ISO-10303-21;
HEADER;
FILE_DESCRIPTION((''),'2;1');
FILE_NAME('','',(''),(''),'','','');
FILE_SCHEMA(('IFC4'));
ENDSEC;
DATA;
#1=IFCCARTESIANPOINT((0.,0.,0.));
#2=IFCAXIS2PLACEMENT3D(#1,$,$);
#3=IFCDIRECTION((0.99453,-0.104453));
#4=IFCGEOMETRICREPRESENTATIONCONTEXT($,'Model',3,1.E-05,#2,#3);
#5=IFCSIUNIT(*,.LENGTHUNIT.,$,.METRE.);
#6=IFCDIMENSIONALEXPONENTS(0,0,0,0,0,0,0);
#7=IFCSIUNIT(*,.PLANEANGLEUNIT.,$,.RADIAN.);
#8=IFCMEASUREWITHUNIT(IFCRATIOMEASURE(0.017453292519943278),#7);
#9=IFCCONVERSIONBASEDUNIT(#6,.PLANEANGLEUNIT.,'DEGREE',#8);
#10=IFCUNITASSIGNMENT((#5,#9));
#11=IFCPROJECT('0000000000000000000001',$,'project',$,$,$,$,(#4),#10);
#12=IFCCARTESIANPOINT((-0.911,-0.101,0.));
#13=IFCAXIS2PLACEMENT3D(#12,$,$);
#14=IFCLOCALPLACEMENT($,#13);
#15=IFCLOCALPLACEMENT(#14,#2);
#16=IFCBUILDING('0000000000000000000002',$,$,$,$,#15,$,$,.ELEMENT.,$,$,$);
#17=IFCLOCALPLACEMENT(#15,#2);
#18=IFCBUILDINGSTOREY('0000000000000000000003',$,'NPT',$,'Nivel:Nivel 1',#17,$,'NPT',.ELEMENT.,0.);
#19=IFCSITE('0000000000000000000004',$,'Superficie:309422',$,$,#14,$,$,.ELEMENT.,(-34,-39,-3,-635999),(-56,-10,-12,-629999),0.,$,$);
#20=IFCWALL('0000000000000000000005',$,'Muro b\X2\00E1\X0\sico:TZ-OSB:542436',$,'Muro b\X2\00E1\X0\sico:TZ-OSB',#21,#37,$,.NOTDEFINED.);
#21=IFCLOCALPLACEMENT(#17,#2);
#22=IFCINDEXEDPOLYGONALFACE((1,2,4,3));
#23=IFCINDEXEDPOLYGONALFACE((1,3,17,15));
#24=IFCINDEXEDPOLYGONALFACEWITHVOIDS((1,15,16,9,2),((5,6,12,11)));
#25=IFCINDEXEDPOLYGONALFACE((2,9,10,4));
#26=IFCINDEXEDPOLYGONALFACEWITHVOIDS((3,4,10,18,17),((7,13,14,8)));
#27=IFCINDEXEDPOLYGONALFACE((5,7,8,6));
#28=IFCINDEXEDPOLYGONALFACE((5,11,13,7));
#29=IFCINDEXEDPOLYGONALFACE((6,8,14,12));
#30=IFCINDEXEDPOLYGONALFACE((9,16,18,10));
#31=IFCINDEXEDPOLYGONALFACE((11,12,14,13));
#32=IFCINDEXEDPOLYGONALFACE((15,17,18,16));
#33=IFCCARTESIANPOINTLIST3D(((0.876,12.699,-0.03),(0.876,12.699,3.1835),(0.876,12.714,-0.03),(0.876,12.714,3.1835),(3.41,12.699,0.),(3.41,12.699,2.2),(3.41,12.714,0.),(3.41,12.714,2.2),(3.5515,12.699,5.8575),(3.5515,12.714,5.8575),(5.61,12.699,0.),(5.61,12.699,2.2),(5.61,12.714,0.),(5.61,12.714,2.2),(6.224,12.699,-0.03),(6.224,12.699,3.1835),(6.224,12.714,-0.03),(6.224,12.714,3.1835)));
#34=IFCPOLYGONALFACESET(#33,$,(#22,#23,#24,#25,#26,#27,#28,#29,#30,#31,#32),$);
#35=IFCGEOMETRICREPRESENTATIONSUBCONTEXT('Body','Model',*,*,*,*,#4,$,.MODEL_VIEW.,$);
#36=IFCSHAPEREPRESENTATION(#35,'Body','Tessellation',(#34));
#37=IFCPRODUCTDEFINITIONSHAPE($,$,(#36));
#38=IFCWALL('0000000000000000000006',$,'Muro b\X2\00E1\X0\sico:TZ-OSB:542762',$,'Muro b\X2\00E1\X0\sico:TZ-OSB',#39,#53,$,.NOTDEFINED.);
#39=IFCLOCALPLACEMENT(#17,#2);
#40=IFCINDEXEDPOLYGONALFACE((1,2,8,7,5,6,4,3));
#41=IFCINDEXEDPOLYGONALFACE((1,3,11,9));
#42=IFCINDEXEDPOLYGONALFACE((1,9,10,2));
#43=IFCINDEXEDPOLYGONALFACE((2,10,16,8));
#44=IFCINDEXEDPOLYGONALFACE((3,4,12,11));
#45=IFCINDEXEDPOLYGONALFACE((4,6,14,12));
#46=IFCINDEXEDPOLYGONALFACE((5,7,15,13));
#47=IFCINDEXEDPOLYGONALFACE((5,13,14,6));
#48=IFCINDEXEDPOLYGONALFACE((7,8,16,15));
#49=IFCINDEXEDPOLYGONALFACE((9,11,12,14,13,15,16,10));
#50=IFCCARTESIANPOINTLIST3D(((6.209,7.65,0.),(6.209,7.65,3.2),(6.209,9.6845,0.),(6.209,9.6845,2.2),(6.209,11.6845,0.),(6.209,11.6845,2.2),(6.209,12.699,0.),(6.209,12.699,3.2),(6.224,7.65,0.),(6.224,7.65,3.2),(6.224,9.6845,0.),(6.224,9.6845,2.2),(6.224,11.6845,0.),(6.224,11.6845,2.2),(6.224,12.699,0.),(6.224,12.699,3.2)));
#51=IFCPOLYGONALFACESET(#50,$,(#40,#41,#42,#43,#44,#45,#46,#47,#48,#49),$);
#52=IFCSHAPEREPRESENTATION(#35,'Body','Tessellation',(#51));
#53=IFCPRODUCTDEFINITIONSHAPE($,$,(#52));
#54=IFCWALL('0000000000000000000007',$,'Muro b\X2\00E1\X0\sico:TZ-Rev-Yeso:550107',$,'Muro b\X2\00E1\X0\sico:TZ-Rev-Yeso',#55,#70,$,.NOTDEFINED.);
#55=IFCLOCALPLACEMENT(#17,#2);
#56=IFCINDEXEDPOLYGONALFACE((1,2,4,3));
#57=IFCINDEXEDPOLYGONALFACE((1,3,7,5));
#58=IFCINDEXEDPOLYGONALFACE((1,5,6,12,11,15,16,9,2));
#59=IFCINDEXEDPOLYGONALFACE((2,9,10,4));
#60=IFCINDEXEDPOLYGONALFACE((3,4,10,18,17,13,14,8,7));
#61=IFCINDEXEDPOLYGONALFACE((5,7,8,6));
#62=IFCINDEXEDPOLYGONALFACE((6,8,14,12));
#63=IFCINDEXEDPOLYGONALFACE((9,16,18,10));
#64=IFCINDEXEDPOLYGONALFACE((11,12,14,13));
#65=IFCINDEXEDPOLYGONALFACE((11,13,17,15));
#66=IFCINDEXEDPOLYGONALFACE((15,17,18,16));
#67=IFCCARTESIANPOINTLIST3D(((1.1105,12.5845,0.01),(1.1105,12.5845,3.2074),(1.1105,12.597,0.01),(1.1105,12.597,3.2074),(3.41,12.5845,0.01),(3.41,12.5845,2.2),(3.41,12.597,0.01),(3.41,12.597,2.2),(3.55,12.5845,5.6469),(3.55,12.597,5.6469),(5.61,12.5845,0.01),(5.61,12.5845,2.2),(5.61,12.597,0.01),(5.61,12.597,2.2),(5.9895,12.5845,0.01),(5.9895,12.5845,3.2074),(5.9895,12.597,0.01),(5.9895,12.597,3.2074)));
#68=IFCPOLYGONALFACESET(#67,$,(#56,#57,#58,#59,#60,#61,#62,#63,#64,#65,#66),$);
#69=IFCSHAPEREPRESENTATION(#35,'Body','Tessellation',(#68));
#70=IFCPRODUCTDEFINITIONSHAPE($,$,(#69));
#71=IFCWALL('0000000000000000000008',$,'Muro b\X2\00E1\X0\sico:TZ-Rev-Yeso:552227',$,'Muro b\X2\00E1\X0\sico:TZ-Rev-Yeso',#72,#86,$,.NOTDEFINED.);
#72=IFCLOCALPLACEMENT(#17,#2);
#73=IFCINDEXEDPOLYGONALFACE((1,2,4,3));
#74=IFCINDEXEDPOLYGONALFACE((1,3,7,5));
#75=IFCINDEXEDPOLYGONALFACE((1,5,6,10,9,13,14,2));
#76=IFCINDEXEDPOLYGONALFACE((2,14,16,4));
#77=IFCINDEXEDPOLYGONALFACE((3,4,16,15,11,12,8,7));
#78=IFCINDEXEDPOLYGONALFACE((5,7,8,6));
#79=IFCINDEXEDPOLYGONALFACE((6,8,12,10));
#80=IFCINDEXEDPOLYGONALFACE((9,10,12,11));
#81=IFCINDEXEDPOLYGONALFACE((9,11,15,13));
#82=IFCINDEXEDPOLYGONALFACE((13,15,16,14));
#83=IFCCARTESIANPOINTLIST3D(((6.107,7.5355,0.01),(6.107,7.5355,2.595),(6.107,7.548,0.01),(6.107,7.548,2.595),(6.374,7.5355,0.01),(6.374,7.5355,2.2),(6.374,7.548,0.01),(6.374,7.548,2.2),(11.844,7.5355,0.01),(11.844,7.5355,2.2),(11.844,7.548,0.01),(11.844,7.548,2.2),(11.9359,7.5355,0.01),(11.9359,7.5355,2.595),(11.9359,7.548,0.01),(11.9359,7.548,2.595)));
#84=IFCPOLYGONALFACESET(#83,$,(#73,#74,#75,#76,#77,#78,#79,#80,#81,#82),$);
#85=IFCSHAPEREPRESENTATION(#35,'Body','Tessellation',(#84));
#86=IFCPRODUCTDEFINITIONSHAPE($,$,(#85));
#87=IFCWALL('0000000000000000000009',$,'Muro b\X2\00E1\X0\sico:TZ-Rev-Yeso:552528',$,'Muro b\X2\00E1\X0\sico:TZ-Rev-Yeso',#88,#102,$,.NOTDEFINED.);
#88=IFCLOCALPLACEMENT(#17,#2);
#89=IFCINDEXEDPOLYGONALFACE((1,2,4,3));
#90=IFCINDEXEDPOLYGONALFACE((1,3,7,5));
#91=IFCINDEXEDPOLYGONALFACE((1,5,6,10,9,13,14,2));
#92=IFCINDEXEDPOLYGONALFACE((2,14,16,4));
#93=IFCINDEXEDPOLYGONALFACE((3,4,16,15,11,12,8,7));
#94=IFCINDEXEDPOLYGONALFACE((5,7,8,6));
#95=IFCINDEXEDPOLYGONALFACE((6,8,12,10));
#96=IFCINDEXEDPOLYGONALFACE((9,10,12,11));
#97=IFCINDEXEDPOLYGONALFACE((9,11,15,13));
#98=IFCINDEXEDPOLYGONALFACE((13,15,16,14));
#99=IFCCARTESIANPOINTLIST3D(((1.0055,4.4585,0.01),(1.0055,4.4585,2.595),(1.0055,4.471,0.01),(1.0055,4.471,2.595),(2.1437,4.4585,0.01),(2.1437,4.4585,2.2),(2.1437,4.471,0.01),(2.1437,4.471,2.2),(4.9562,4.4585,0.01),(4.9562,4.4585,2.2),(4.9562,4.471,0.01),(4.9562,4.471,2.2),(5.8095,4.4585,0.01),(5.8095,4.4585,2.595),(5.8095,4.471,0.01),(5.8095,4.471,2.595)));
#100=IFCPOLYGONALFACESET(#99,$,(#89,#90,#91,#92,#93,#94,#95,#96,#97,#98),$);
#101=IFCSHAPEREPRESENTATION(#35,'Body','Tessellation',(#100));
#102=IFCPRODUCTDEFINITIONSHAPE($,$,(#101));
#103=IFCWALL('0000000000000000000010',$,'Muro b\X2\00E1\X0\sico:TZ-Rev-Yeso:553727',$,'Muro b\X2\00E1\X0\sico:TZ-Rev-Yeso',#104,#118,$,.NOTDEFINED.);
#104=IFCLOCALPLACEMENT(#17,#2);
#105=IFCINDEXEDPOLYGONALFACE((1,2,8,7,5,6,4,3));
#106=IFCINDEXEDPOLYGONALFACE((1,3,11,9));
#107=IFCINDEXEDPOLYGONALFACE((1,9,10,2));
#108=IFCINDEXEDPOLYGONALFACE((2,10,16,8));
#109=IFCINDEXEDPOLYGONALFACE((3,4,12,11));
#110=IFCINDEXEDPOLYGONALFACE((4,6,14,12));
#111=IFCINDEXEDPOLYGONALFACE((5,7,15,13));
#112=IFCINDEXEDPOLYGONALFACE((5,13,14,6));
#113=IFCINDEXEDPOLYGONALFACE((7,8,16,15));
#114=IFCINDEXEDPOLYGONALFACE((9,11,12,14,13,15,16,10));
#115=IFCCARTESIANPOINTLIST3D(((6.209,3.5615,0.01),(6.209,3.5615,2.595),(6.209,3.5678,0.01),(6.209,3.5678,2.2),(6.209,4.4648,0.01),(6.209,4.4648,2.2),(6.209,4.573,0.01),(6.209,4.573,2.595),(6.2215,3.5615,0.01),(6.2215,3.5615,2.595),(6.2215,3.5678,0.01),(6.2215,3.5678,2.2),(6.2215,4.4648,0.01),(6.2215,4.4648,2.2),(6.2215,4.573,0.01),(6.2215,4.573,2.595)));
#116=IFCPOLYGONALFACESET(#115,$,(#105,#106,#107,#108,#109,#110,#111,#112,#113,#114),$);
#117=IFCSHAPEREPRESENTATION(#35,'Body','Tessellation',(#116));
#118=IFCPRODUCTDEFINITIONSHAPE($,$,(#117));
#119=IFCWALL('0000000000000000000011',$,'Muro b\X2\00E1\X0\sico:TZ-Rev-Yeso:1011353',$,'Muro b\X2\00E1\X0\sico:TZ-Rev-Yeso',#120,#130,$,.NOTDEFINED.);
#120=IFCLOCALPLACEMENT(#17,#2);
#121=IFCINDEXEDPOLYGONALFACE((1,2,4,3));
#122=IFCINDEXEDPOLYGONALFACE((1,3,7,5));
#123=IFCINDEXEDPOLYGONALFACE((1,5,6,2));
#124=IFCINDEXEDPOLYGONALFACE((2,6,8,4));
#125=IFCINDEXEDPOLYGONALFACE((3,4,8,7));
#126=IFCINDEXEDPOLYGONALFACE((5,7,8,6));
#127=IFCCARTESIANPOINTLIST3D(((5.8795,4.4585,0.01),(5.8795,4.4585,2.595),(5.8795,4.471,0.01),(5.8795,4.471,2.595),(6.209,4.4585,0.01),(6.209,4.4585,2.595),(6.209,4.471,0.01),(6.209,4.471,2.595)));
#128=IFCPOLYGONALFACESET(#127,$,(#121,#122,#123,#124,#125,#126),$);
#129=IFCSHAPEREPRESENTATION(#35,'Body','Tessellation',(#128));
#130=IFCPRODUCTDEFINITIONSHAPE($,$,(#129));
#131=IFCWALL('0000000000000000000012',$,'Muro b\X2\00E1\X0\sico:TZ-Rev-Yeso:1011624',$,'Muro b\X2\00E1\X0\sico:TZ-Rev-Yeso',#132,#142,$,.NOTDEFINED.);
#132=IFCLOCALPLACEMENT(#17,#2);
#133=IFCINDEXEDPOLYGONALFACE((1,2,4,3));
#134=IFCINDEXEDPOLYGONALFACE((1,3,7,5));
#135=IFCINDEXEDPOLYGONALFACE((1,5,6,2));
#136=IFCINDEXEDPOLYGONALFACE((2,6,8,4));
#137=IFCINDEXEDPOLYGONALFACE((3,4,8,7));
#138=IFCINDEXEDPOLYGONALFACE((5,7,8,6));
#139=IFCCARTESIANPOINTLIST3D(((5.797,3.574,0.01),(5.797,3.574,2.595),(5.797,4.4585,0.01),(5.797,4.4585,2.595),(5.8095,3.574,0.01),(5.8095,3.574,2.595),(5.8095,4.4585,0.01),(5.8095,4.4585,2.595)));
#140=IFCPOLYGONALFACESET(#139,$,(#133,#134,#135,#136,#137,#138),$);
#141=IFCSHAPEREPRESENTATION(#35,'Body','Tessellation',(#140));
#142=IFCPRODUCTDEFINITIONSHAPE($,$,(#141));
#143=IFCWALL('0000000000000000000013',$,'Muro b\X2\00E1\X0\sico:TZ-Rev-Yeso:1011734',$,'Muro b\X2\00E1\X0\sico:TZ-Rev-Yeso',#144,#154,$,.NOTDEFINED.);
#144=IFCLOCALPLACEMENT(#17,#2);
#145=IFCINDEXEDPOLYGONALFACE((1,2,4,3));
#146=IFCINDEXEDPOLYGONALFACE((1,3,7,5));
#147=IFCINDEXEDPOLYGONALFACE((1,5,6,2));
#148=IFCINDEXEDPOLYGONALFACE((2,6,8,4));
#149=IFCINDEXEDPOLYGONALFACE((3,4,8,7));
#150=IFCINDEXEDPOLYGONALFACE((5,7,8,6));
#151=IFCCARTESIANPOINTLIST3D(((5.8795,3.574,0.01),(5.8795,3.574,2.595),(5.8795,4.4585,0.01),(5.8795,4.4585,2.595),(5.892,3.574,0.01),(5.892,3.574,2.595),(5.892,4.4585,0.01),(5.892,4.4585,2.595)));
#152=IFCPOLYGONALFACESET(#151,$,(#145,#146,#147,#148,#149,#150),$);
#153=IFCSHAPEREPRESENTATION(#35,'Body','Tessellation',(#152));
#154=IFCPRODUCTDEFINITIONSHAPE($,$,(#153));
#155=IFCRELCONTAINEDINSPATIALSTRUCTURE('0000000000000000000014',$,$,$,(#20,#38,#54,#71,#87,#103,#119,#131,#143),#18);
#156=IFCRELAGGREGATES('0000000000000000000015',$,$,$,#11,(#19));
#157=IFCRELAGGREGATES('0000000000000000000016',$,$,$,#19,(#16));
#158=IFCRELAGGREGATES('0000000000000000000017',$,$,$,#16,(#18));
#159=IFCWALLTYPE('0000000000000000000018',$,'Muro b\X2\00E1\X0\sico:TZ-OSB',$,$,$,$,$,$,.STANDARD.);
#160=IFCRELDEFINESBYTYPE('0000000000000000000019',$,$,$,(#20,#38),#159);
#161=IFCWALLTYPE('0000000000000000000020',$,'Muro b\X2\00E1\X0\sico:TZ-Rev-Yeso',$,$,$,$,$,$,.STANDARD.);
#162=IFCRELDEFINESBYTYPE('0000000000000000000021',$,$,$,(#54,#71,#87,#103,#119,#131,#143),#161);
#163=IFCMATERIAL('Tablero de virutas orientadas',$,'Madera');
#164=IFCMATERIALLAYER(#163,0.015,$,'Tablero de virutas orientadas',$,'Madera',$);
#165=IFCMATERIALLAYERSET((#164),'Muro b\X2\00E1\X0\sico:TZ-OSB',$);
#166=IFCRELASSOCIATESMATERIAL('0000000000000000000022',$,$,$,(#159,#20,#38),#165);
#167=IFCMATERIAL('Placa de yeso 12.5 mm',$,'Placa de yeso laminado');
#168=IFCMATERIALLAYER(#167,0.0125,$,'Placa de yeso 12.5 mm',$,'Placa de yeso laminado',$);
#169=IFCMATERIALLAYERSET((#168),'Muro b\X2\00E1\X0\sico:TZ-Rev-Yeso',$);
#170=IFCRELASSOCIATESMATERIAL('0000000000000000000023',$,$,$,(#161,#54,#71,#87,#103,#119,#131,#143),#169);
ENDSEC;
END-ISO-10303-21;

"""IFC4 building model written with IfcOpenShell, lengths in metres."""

from ifc_helpers import new_model, entity, si_unit, converted_unit, direction, frame, frame_2d, origin, origin_2d_with_axis, place, context, subcontext, project, spatial, rectangle, extrude, clip, halfspace, material, layer, layer_set, layer_usage, type_object, element, save


model = new_model("IFC4")

# Units and contexts
model_context = context("Model", 3, precision=1e-05, world=origin(), true_north=direction((0.99453, -0.104453)))
body_context = subcontext(model_context, "Body", "Model", "MODEL_VIEW")
ifc_project = project(units=[si_unit("LENGTHUNIT", "METRE"), converted_unit("PLANEANGLEUNIT", "DEGREE", entity("IfcRatioMeasure", 0.017453292519943278), si_unit("PLANEANGLEUNIT", "RADIAN"), dimensions=[0, 0, 0, 0, 0, 0, 0])], contexts=[model_context])

# Site, building, storey
site_placement = place(None, frame((-0.911, -0.101, 0.0)))
site = spatial("IfcSite", under=ifc_project, at=site_placement, Name="Superficie:309422", CompositionType="ELEMENT", RefLatitude=(-34, -39, -3, -635999), RefLongitude=(-56, -10, -12, -629999), RefElevation=0.0)
building_placement = place(site_placement, origin())
building = spatial("IfcBuilding", under=site, at=building_placement, CompositionType="ELEMENT")
storey_placement = place(building_placement, origin())
storey = spatial("IfcBuildingStorey", under=building, at=storey_placement, Name="NPT", ObjectType="Nivel:Nivel 1", LongName="NPT", CompositionType="ELEMENT", Elevation=0.0)

# Walls, openings
ifc_material_1 = material(Name="Tablero de virutas orientadas", Category="Madera")
ifc_layer_1 = layer(ifc_material_1, 0.015, Name="Tablero de virutas orientadas", Category="Madera")
ifc_layer_set_1 = layer_set([ifc_layer_1], Name="Muro básico:TZ-OSB")
ifc_layer_usage_1 = layer_usage(ifc_layer_set_1, "AXIS2", "NEGATIVE", 0.0075)
wall_type_1 = type_object("IfcWallType", Name="Muro básico:TZ-OSB", PredefinedType="STANDARD", material=ifc_layer_set_1)
wall_1_placement = place(storey_placement, frame((0.876, 12.7065, -0.03)))
wall_1 = element("IfcWall", 1, at=wall_1_placement, inside=storey, type_object=wall_type_1, material=ifc_layer_usage_1, Name="Muro básico:TZ-OSB:542436", ObjectType="Muro básico:TZ-OSB", PredefinedType="NOTDEFINED", context=body_context, shape_type="Clipping", body=[
    clip(clip(extrude(rectangle(XDim=5.348, YDim=0.015, at=frame_2d((2.674, 0.0), x_axis=(-1.0, 0.0))), origin(), (0.0, 0.0, 1.0), 5.8875), halfspace(frame((2.6755, -0.0075, 5.8875), z_axis=(0.707306, 0.0, 0.706908), x_axis=(0.0, 1.0, 0.0)), False)), halfspace(frame((0.0, -0.0075, 3.2135), z_axis=(-0.706908, 0.0, 0.707306), x_axis=(0.0, 1.0, 0.0)), False)),
])
opening_1_placement = place(wall_1_placement, frame((2.534, -1.6335, 0.03)))
element("IfcOpeningElement", 2, at=opening_1_placement, cuts=wall_1, PredefinedType="OPENING", context=body_context, shape_type="SweptSolid", body=[
    extrude(rectangle(XDim=2.2, YDim=2.2, at=origin_2d_with_axis()), frame((1.1, 0.0, 1.1), z_axis=(0.0, 1.0, 0.0), x_axis=(0.0, 0.0, 1.0)), (0.0, 0.0, 1.0), 3.048),
])
ifc_layer_usage_2 = layer_usage(ifc_layer_set_1, "AXIS2", "NEGATIVE", 0.0075)
wall_2_placement = place(storey_placement, frame((6.2165, 12.699, 0.0), z_axis=(0.0, 0.0, 1.0), x_axis=(0.0, -1.0, 0.0)))
wall_2 = element("IfcWall", 3, at=wall_2_placement, inside=storey, type_object=wall_type_1, material=ifc_layer_usage_2, Name="Muro básico:TZ-OSB:542762", ObjectType="Muro básico:TZ-OSB", PredefinedType="NOTDEFINED", context=body_context, shape_type="SweptSolid", body=[
    extrude(rectangle(XDim=5.049, YDim=0.015, at=frame_2d((2.5245, 0.0), x_axis=(1.0, 0.0))), origin(), (0.0, 0.0, 1.0), 3.2),
])
opening_2_placement = place(wall_2_placement, frame((3.0145, -1.6335, 0.0)))
element("IfcOpeningElement", 4, at=opening_2_placement, cuts=wall_2, PredefinedType="OPENING", context=body_context, shape_type="SweptSolid", body=[
    extrude(rectangle(XDim=2.2, YDim=2.0, at=frame_2d((0.0, 0.0), x_axis=(1.0, 0.0))), frame((-1.0, 0.0, 1.1), z_axis=(0.0, 1.0, 0.0), x_axis=(0.0, 0.0, 1.0)), (0.0, 0.0, 1.0), 3.048),
])
ifc_material_2 = material(Name="Placa de yeso 12.5 mm", Category="Placa de yeso laminado")
ifc_layer_2 = layer(ifc_material_2, 0.0125, Name="Placa de yeso 12.5 mm", Category="Placa de yeso laminado")
ifc_layer_set_2 = layer_set([ifc_layer_2], Name="Muro básico:TZ-Rev-Yeso")
ifc_layer_usage_3 = layer_usage(ifc_layer_set_2, "AXIS2", "NEGATIVE", 0.0063)
wall_type_2 = type_object("IfcWallType", Name="Muro básico:TZ-Rev-Yeso", PredefinedType="STANDARD", material=ifc_layer_set_2)
wall_3_placement = place(storey_placement, frame((1.1105, 12.5908, 0.01)))
wall_3 = element("IfcWall", 5, at=wall_3_placement, inside=storey, type_object=wall_type_2, material=ifc_layer_usage_3, Name="Muro básico:TZ-Rev-Yeso:550107", ObjectType="Muro básico:TZ-Rev-Yeso", PredefinedType="NOTDEFINED", context=body_context, shape_type="Clipping", body=[
    clip(clip(extrude(rectangle(XDim=4.879, YDim=0.0125, at=frame_2d((2.4395, 0.0), x_axis=(-1.0, 0.0))), origin(), (0.0, 0.0, 1.0), 5.6369), halfspace(frame((0.0, -0.0062, 3.1974), z_axis=(-0.707107, 0.0, 0.707107), x_axis=(0.0, 1.0, 0.0)), False)), halfspace(frame((2.4395, -0.0062, 5.6369), z_axis=(0.707107, 0.0, 0.707107), x_axis=(0.0, 1.0, 0.0)), False)),
])
opening_3_placement = place(wall_3_placement, frame((2.2995, -1.5177, -0.01)))
element("IfcOpeningElement", 6, at=opening_3_placement, cuts=wall_3, PredefinedType="OPENING", context=body_context, shape_type="SweptSolid", body=[
    extrude(rectangle(XDim=2.2, YDim=2.2, at=origin_2d_with_axis()), frame((1.1, 0.0, 1.1), z_axis=(0.0, 1.0, 0.0), x_axis=(0.0, 0.0, 1.0)), (0.0, 0.0, 1.0), 3.048),
])
ifc_layer_usage_4 = layer_usage(ifc_layer_set_2, "AXIS2", "NEGATIVE", 0.0063)
wall_4_placement = place(storey_placement, frame((6.107, 7.5417, 0.01)))
wall_4 = element("IfcWall", 7, at=wall_4_placement, inside=storey, type_object=wall_type_2, material=ifc_layer_usage_4, Name="Muro básico:TZ-Rev-Yeso:552227", ObjectType="Muro básico:TZ-Rev-Yeso", PredefinedType="NOTDEFINED", context=body_context, shape_type="SweptSolid", body=[
    extrude(rectangle(XDim=5.8289, YDim=0.0125, at=frame_2d((2.9145, 0.0), x_axis=(1.0, 0.0))), origin(), (0.0, 0.0, 1.0), 2.585),
])
opening_4_placement = place(wall_4_placement, frame((0.267, -1.5178, -0.01)))
element("IfcOpeningElement", 8, at=opening_4_placement, cuts=wall_4, PredefinedType="OPENING", context=body_context, shape_type="SweptSolid", body=[
    extrude(rectangle(XDim=2.2, YDim=5.47, at=frame_2d((0.0, 0.0), x_axis=(1.0, 0.0))), frame((2.735, 0.0, 1.1), z_axis=(0.0, 1.0, 0.0), x_axis=(0.0, 0.0, -1.0)), (0.0, 0.0, 1.0), 3.048),
])
ifc_layer_usage_5 = layer_usage(ifc_layer_set_2, "AXIS2", "NEGATIVE", 0.0063)
wall_5_placement = place(storey_placement, frame((1.0055, 4.4648, 0.01)))
wall_5 = element("IfcWall", 9, at=wall_5_placement, inside=storey, type_object=wall_type_2, material=ifc_layer_usage_5, Name="Muro básico:TZ-Rev-Yeso:552528", ObjectType="Muro básico:TZ-Rev-Yeso", PredefinedType="NOTDEFINED", context=body_context, shape_type="SweptSolid", body=[
    extrude(rectangle(XDim=4.804, YDim=0.0125, at=frame_2d((2.402, 0.0), x_axis=(-1.0, 0.0))), origin(), (0.0, 0.0, 1.0), 2.585),
])
opening_5_placement = place(wall_5_placement, origin())
element("IfcOpeningElement", 10, at=opening_5_placement, cuts=wall_5, PredefinedType="OPENING", context=body_context, shape_type="SweptSolid", body=[
    extrude(rectangle(XDim=2.19, YDim=2.8125, at=frame_2d((0.0, 0.0), x_axis=(0.0, 1.0))), frame((2.5445, 0.0063, 1.095), z_axis=(0.0, -1.0, 0.0), x_axis=(1.0, 0.0, 0.0)), (0.0, 0.0, 1.0), 0.0125),
])

# Wall, opening
ifc_layer_usage_6 = layer_usage(ifc_layer_set_2, "AXIS2", "POSITIVE", -0.0063)
wall_6_placement = place(storey_placement, frame((6.2153, 4.573, 0.01), z_axis=(0.0, 0.0, 1.0), x_axis=(0.0, -1.0, 0.0)))
wall_6 = element("IfcWall", 11, at=wall_6_placement, inside=storey, type_object=wall_type_2, material=ifc_layer_usage_6, Name="Muro básico:TZ-Rev-Yeso:553727", ObjectType="Muro básico:TZ-Rev-Yeso", PredefinedType="NOTDEFINED", context=body_context, shape_type="SweptSolid", body=[
    extrude(rectangle(XDim=1.0115, YDim=0.0125, at=frame_2d((0.5057, 0.0), x_axis=(-1.0, 0.0))), origin(), (0.0, 0.0, 1.0), 2.585),
])
opening_6_placement = place(wall_6_placement, origin())
element("IfcOpeningElement", 12, at=opening_6_placement, cuts=wall_6, PredefinedType="OPENING", context=body_context, shape_type="SweptSolid", body=[
    extrude(rectangle(XDim=2.19, YDim=0.897, at=frame_2d((0.0, 0.0), x_axis=(0.0, 1.0))), frame((0.5567, 0.0062, 1.095), z_axis=(0.0, -1.0, 0.0), x_axis=(-1.0, 0.0, 0.0)), (0.0, 0.0, 1.0), 0.0125),
])

# Walls
ifc_layer_usage_7 = layer_usage(ifc_layer_set_2, "AXIS2", "NEGATIVE", 0.0063)
wall_7_placement = place(storey_placement, frame((5.8795, 4.4648, 0.01)))
element("IfcWall", 13, at=wall_7_placement, inside=storey, type_object=wall_type_2, material=ifc_layer_usage_7, Name="Muro básico:TZ-Rev-Yeso:1011353", ObjectType="Muro básico:TZ-Rev-Yeso", PredefinedType="NOTDEFINED", context=body_context, shape_type="SweptSolid", body=[
    extrude(rectangle(XDim=0.3295, YDim=0.0125, at=frame_2d((0.1647, 0.0), x_axis=(-1.0, 0.0))), origin(), (0.0, 0.0, 1.0), 2.585),
])
ifc_layer_usage_8 = layer_usage(ifc_layer_set_2, "AXIS2", "NEGATIVE", 0.0063)
wall_8_placement = place(storey_placement, frame((5.8033, 4.4585, 0.01), z_axis=(0.0, 0.0, 1.0), x_axis=(0.0, -1.0, 0.0)))
element("IfcWall", 14, at=wall_8_placement, inside=storey, type_object=wall_type_2, material=ifc_layer_usage_8, Name="Muro básico:TZ-Rev-Yeso:1011624", ObjectType="Muro básico:TZ-Rev-Yeso", PredefinedType="NOTDEFINED", context=body_context, shape_type="SweptSolid", body=[
    extrude(rectangle(XDim=0.8845, YDim=0.0125, at=frame_2d((0.4422, 0.0), x_axis=(-1.0, 0.0))), origin(), (0.0, 0.0, 1.0), 2.585),
])
ifc_layer_usage_9 = layer_usage(ifc_layer_set_2, "AXIS2", "NEGATIVE", 0.0063)
wall_9_placement = place(storey_placement, frame((5.8858, 3.574, 0.01), z_axis=(0.0, 0.0, 1.0), x_axis=(0.0, 1.0, 0.0)))
element("IfcWall", 15, at=wall_9_placement, inside=storey, type_object=wall_type_2, material=ifc_layer_usage_9, Name="Muro básico:TZ-Rev-Yeso:1011734", ObjectType="Muro básico:TZ-Rev-Yeso", PredefinedType="NOTDEFINED", context=body_context, shape_type="SweptSolid", body=[
    extrude(rectangle(XDim=0.8845, YDim=0.0125, at=frame_2d((0.4422, 0.0), x_axis=(-1.0, 0.0))), origin(), (0.0, 0.0, 1.0), 2.585),
])

save(model, "model.ifc")
